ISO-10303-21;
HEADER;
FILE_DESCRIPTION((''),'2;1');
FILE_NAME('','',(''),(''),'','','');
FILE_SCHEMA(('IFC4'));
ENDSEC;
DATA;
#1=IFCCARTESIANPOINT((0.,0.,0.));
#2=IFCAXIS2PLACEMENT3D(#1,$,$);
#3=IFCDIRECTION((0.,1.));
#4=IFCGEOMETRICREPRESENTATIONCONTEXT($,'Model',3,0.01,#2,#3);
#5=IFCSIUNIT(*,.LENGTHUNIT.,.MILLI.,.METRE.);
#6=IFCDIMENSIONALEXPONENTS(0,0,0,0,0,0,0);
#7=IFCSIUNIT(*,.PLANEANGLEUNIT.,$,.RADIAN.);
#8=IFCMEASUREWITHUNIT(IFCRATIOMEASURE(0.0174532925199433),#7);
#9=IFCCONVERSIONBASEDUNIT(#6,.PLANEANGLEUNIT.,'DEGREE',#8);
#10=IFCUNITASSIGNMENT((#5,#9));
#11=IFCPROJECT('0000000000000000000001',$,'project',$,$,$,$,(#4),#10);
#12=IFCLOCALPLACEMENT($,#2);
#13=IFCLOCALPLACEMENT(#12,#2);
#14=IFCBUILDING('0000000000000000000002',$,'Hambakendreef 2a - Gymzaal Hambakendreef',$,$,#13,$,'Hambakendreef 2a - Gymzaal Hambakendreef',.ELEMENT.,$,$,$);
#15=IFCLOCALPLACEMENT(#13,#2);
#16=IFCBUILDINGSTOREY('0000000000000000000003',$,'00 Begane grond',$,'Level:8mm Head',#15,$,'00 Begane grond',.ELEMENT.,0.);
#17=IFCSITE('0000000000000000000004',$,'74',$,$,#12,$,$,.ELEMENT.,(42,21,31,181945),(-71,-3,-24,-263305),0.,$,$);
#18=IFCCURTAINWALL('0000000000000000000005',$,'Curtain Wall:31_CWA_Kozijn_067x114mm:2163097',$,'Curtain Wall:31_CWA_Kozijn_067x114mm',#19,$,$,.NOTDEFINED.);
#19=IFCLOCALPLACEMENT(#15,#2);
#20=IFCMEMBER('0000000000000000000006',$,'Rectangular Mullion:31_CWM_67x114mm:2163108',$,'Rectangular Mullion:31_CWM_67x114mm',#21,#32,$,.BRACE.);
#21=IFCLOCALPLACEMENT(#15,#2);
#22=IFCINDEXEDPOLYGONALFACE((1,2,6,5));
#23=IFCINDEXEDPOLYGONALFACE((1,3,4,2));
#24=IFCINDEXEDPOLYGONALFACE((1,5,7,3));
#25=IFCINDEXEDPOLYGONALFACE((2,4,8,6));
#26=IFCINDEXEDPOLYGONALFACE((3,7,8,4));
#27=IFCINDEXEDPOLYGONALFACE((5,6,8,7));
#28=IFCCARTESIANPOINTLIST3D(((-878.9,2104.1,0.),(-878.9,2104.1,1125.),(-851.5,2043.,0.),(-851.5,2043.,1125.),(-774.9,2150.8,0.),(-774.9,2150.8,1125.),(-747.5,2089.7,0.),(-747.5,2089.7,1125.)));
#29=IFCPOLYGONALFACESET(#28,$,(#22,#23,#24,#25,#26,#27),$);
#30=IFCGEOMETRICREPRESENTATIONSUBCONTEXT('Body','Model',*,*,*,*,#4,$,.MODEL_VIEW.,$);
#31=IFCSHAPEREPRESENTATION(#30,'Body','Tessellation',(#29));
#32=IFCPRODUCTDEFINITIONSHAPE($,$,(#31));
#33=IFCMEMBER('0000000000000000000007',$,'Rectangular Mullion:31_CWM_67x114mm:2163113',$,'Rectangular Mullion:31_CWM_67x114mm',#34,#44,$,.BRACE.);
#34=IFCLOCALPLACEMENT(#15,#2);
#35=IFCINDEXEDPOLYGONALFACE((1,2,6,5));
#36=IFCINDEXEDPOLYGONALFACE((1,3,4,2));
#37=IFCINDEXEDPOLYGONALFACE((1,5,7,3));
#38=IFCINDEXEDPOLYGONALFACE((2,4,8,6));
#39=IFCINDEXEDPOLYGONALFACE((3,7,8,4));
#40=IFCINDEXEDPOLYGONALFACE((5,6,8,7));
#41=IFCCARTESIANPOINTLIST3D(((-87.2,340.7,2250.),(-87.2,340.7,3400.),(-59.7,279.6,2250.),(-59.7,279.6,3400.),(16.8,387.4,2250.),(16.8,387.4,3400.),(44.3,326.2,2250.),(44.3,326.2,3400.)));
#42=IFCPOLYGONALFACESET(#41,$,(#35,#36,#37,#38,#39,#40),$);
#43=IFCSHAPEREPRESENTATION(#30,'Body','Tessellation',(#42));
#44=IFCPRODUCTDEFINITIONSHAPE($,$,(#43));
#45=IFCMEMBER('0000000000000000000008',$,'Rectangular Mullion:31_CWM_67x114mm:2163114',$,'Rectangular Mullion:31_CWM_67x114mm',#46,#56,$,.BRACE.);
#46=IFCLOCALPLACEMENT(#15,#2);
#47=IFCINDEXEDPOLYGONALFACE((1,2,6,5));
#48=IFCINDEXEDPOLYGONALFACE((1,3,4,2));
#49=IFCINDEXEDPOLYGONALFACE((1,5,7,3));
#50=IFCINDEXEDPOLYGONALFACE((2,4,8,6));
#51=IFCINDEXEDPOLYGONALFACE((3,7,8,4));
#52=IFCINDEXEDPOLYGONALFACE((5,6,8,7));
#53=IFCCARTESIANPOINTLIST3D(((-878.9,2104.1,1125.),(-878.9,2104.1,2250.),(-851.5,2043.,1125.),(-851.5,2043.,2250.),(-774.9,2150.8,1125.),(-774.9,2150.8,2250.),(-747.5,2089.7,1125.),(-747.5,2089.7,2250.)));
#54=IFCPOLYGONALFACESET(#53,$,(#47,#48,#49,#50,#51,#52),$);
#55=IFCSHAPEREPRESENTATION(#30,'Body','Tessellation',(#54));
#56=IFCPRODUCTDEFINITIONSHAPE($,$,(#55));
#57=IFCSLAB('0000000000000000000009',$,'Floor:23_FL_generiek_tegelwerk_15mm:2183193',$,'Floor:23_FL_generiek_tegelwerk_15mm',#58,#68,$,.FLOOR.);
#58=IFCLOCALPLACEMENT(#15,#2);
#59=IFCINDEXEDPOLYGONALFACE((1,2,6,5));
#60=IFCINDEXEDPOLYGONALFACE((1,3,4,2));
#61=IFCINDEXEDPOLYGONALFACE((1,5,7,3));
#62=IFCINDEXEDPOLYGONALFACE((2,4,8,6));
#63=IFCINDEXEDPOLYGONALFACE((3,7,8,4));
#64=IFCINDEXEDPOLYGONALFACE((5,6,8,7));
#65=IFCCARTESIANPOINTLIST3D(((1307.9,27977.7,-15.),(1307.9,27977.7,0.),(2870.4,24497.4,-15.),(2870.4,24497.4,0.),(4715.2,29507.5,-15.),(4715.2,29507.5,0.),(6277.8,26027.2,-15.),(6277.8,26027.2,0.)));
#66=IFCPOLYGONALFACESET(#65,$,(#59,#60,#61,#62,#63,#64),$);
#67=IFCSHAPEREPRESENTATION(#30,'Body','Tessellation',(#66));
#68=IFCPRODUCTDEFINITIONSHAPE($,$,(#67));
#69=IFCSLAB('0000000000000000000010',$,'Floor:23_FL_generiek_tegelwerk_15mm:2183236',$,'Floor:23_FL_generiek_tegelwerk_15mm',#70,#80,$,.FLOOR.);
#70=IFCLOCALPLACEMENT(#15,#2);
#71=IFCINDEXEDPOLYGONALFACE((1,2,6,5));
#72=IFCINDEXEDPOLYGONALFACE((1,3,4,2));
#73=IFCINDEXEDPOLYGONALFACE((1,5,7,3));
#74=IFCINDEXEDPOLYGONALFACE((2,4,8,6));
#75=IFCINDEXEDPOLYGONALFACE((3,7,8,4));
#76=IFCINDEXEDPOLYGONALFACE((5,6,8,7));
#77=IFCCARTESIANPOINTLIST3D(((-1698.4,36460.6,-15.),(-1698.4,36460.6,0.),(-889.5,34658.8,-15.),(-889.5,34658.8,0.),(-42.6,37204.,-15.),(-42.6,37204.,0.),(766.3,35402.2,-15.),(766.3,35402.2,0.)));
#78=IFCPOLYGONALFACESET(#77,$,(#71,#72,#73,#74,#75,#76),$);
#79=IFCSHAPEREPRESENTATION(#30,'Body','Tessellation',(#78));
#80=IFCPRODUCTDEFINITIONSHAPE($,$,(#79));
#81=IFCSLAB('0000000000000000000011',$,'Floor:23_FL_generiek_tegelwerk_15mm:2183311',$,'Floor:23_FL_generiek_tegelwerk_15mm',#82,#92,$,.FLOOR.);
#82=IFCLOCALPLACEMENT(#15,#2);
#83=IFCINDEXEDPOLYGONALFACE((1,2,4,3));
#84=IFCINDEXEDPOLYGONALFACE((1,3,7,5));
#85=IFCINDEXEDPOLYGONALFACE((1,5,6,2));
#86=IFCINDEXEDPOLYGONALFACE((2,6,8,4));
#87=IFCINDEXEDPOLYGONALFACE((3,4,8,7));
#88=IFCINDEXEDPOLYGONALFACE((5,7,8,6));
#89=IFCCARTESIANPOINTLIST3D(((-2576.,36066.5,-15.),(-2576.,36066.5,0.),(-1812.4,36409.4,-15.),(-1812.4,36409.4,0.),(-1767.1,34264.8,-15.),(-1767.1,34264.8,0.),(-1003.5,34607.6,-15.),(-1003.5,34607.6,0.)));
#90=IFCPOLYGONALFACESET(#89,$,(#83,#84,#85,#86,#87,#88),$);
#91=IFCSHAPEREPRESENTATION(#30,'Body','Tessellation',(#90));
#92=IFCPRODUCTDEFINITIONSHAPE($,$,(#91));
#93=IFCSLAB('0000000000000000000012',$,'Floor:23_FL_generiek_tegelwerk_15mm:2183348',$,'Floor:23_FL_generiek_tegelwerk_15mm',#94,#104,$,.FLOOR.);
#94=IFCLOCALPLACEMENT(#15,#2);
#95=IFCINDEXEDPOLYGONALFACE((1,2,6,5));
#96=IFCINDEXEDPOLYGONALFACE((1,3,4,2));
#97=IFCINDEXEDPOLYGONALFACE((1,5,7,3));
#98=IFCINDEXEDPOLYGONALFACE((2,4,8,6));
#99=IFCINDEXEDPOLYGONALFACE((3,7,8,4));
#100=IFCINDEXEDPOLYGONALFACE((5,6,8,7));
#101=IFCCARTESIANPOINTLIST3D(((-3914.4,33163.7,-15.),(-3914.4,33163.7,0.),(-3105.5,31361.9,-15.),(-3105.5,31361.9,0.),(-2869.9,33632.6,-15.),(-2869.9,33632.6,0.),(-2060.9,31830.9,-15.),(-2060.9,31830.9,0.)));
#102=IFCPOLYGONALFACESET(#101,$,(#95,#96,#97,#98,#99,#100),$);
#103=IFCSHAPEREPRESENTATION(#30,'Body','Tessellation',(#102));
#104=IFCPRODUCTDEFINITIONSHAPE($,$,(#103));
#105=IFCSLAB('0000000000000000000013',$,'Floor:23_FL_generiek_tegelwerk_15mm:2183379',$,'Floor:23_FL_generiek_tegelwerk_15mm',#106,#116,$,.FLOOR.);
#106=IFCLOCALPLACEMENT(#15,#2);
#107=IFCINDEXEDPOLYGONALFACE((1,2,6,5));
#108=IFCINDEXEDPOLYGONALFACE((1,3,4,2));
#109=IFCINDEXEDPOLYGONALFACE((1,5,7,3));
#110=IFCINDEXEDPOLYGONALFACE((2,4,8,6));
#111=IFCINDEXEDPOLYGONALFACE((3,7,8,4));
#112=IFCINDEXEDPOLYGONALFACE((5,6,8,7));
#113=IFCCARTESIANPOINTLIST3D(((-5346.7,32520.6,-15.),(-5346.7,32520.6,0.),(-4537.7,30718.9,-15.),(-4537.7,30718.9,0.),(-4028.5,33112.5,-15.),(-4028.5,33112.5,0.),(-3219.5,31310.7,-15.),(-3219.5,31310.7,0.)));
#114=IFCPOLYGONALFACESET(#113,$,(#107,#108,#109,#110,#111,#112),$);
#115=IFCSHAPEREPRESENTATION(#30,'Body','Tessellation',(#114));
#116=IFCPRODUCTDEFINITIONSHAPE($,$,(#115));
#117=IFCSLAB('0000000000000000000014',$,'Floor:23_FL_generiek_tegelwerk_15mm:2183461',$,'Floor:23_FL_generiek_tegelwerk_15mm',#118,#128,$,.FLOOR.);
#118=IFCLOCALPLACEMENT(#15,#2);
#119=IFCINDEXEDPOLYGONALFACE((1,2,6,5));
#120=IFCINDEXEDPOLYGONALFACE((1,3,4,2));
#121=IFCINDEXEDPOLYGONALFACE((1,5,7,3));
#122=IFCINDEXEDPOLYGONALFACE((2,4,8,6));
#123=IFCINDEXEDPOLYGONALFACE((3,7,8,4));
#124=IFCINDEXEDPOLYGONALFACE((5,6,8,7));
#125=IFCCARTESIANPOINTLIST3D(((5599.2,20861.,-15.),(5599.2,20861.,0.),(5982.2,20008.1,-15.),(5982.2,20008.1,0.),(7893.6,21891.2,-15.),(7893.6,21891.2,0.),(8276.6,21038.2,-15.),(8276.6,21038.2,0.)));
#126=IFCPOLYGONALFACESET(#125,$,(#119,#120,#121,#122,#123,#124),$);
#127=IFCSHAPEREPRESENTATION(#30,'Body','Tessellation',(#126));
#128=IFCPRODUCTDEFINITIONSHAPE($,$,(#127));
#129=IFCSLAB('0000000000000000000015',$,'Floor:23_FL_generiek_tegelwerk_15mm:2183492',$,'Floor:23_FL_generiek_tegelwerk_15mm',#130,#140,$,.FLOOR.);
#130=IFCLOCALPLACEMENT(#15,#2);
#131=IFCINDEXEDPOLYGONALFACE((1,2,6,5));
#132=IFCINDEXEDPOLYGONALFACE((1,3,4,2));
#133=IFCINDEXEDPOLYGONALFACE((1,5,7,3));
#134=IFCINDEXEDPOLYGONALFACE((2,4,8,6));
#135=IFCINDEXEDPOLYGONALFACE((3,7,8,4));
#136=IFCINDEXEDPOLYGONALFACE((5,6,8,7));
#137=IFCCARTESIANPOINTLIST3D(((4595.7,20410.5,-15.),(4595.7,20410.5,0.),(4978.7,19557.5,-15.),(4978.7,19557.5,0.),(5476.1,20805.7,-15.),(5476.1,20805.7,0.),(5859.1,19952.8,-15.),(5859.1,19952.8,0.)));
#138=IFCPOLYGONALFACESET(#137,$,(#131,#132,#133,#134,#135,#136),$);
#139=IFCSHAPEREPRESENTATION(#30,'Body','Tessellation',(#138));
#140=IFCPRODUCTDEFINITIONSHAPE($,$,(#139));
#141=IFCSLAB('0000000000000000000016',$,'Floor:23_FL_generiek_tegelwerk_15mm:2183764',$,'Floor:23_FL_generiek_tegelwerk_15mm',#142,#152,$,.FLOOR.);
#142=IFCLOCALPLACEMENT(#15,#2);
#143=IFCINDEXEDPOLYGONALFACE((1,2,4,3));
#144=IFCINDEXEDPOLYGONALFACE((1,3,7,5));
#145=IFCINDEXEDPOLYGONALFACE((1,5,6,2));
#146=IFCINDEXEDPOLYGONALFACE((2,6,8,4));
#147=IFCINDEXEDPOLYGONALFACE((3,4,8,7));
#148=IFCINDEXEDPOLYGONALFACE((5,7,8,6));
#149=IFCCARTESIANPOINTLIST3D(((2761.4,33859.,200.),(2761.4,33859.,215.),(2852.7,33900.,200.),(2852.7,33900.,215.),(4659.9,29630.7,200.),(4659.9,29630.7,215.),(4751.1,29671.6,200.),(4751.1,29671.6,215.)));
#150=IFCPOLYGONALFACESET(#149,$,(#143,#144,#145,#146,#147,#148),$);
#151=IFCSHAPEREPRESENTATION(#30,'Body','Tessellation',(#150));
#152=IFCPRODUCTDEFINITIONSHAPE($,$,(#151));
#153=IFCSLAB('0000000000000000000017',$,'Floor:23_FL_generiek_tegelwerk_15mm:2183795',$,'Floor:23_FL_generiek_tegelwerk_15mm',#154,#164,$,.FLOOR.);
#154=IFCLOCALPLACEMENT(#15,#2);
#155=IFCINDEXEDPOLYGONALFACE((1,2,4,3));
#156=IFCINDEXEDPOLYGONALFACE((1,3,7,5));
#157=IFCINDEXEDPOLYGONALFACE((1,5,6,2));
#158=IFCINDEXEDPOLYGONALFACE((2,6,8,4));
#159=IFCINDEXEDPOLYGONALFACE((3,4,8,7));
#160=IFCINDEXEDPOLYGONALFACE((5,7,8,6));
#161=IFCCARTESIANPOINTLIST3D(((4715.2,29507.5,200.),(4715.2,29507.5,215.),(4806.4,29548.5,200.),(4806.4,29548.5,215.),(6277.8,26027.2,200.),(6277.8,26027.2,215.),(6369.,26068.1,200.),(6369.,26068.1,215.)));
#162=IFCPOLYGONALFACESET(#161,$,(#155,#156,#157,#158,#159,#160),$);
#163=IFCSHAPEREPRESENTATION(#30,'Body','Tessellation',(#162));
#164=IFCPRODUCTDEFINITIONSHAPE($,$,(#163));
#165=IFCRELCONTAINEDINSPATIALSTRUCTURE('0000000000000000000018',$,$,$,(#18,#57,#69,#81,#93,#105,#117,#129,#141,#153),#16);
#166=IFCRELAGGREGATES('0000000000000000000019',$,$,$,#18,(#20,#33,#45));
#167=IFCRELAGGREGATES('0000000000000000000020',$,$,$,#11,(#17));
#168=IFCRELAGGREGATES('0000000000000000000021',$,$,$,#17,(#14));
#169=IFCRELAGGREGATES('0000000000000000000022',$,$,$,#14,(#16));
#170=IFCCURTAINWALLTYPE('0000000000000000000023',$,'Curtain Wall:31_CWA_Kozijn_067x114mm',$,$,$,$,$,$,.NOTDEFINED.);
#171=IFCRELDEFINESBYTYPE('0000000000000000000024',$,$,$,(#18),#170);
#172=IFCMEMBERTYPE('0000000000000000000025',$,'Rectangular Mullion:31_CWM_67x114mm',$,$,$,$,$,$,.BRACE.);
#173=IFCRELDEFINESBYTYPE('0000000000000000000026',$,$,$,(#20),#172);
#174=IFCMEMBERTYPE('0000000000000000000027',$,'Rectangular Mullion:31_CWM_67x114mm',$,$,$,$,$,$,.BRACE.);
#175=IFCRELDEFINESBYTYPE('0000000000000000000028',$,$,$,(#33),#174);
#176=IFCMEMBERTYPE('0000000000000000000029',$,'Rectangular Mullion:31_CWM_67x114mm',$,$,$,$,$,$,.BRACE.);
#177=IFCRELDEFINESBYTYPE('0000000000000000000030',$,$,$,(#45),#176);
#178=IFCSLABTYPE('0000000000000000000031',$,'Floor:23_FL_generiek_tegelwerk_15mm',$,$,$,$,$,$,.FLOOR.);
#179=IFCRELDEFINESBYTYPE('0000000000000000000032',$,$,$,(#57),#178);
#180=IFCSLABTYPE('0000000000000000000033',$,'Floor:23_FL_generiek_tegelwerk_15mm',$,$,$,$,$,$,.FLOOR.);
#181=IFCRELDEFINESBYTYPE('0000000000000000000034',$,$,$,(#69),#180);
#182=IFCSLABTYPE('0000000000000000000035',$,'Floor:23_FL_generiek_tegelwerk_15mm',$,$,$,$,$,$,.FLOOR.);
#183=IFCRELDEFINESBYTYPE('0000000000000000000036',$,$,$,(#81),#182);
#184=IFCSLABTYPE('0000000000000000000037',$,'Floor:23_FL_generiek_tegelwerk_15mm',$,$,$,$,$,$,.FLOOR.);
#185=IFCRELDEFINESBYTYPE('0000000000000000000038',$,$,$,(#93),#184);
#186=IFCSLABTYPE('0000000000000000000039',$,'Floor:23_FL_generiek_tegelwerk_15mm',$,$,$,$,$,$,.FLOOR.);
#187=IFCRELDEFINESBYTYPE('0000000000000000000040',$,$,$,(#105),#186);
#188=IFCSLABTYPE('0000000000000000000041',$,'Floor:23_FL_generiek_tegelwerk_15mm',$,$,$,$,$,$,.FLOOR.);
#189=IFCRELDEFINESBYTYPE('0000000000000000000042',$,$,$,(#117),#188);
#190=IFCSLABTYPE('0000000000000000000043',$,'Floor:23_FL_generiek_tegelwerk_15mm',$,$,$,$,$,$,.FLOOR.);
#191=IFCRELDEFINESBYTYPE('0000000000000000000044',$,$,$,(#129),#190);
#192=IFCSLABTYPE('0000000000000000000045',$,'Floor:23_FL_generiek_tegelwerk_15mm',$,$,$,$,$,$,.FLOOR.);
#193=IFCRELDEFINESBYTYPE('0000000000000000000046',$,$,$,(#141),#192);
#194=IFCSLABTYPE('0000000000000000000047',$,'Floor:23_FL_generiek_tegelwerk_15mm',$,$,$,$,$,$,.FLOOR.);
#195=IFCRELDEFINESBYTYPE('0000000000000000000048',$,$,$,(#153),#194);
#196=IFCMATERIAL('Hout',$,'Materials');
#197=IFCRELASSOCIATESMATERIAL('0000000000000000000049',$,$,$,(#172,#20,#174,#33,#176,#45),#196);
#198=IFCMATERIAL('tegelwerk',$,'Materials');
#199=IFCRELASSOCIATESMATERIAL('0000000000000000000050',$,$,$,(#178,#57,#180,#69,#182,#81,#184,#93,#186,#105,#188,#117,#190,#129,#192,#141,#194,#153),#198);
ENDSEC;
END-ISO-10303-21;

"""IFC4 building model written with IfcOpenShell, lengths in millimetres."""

from ifc_helpers import new_model, entity, si_unit, converted_unit, direction, frame, origin, place, context, subcontext, project, spatial, indexed_curve, outline, extrude, source, transform, mapped, material, type_object, type_shapes, element, aggregate, save


model = new_model("IFC4")

# Units and contexts
model_context = context("Model", 3, precision=0.01, world=origin(), true_north=direction((0.0, 1.0)))
body_context = subcontext(model_context, "Body", "Model", "MODEL_VIEW")
ifc_project = project(units=[si_unit("LENGTHUNIT", "METRE", prefix="MILLI"), converted_unit("PLANEANGLEUNIT", "DEGREE", entity("IfcRatioMeasure", 0.0174532925199433), si_unit("PLANEANGLEUNIT", "RADIAN"), dimensions=[0, 0, 0, 0, 0, 0, 0])], contexts=[model_context])

# Site, building, storey
site_placement = place(None, origin())
site = spatial("IfcSite", under=ifc_project, at=site_placement, Name="74", CompositionType="ELEMENT", RefLatitude=(42, 21, 31, 181945), RefLongitude=(-71, -3, -24, -263305), RefElevation=0.0)
building_placement = place(site_placement, origin())
building = spatial("IfcBuilding", under=site, at=building_placement, Name="Hambakendreef 2a - Gymzaal Hambakendreef", LongName="Hambakendreef 2a - Gymzaal Hambakendreef", CompositionType="ELEMENT")
storey_placement = place(building_placement, origin())
storey = spatial("IfcBuildingStorey", under=building, at=storey_placement, Name="00 Begane grond", ObjectType="Level:8mm Head", LongName="00 Begane grond", CompositionType="ELEMENT", Elevation=0.0)

# Curtain wall, members
curtain_wall_type = type_object("IfcCurtainWallType", Name="Curtain Wall:31_CWA_Kozijn_067x114mm", PredefinedType="NOTDEFINED")
curtain_wall_placement = place(storey_placement, origin())
curtain_wall = element("IfcCurtainWall", 1, at=curtain_wall_placement, inside=storey, type_object=curtain_wall_type, Name="Curtain Wall:31_CWA_Kozijn_067x114mm:2163097", ObjectType="Curtain Wall:31_CWA_Kozijn_067x114mm", PredefinedType="NOTDEFINED")
ifc_material_1 = material(Name="Hout", Category="Materials")
member_type_1 = type_object("IfcMemberType", Name="Rectangular Mullion:31_CWM_67x114mm", PredefinedType="BRACE", material=ifc_material_1)
shared_shape_1 = source(origin(), body_context, "Body", "SweptSolid", [
    extrude(outline(indexed_curve([(-57.0, -33.5), (57.0, -33.5), (57.0, 33.5), (-57.0, 33.5), (-57.0, -33.5)], self_intersect=False)), frame((-33.5, 0.0, -1125.0), z_axis=(0.0, 0.0, 1.0), x_axis=(0.0, -1.0, 0.0)), (0.0, 0.0, 1.0), 1125.0),
])
type_shapes(member_type_1, [shared_shape_1])
member_1_placement = place(storey_placement, frame((-826.9, 2127.4, 1125.0), z_axis=(0.0, 0.0, 1.0), x_axis=(-0.40959, 0.91227, 0.0)))
member_1 = element("IfcMember", 2, at=member_1_placement, type_object=member_type_1, material=ifc_material_1, Name="Rectangular Mullion:31_CWM_67x114mm:2163108", ObjectType="Rectangular Mullion:31_CWM_67x114mm", PredefinedType="BRACE", context=body_context, shape_type="MappedRepresentation", body=[
    mapped(shared_shape_1, transform((0.0, 0.0, 0.0), scale=1.0)),
])
member_type_2 = type_object("IfcMemberType", Name="Rectangular Mullion:31_CWM_67x114mm", PredefinedType="BRACE", material=ifc_material_1)
shared_shape_2 = source(origin(), body_context, "Body", "SweptSolid", [
    extrude(outline(indexed_curve([(-57.0, -33.5), (57.0, -33.5), (57.0, 33.5), (-57.0, 33.5), (-57.0, -33.5)], self_intersect=False)), frame((-33.5, 0.0, -1150.0), z_axis=(0.0, 0.0, 1.0), x_axis=(0.0, -1.0, 0.0)), (0.0, 0.0, 1.0), 1150.0),
])
type_shapes(member_type_2, [shared_shape_2])
member_2_placement = place(storey_placement, frame((-7.7, 302.9, 2250.0), z_axis=(0.0, 0.0, -1.0), x_axis=(0.40959, -0.91227, 0.0)))
member_2 = element("IfcMember", 3, at=member_2_placement, type_object=member_type_2, material=ifc_material_1, Name="Rectangular Mullion:31_CWM_67x114mm:2163113", ObjectType="Rectangular Mullion:31_CWM_67x114mm", PredefinedType="BRACE", context=body_context, shape_type="MappedRepresentation", body=[
    mapped(shared_shape_2, transform((0.0, 0.0, 0.0), scale=1.0)),
])
member_type_3 = type_object("IfcMemberType", Name="Rectangular Mullion:31_CWM_67x114mm", PredefinedType="BRACE", material=ifc_material_1)
shared_shape_3 = source(origin(), body_context, "Body", "SweptSolid", [
    extrude(outline(indexed_curve([(-57.0, -33.5), (57.0, -33.5), (57.0, 33.5), (-57.0, 33.5), (-57.0, -33.5)], self_intersect=False)), frame((-33.5, 0.0, -1125.0), z_axis=(0.0, 0.0, 1.0), x_axis=(0.0, -1.0, 0.0)), (0.0, 0.0, 1.0), 1125.0),
])
type_shapes(member_type_3, [shared_shape_3])
member_3_placement = place(storey_placement, frame((-826.9, 2127.4, 2250.0), z_axis=(0.0, 0.0, 1.0), x_axis=(-0.40959, 0.91227, 0.0)))
member_3 = element("IfcMember", 4, at=member_3_placement, type_object=member_type_3, material=ifc_material_1, Name="Rectangular Mullion:31_CWM_67x114mm:2163114", ObjectType="Rectangular Mullion:31_CWM_67x114mm", PredefinedType="BRACE", context=body_context, shape_type="MappedRepresentation", body=[
    mapped(shared_shape_3, transform((0.0, 0.0, 0.0), scale=1.0)),
])
aggregate(curtain_wall, [member_1, member_2, member_3])

# Slabs
ifc_material_2 = material(Name="tegelwerk", Category="Materials")
slab_type_1 = type_object("IfcSlabType", Name="Floor:23_FL_generiek_tegelwerk_15mm", PredefinedType="FLOOR", material=ifc_material_2)
slab_1_placement = place(storey_placement, origin())
element("IfcSlab", 5, at=slab_1_placement, inside=storey, type_object=slab_type_1, material=ifc_material_2, Name="Floor:23_FL_generiek_tegelwerk_15mm:2183193", ObjectType="Floor:23_FL_generiek_tegelwerk_15mm", PredefinedType="FLOOR", context=body_context, shape_type="SweptSolid", body=[
    extrude(outline(indexed_curve([(-1907.5, -1867.5), (1907.5, -1867.5), (1907.5, 1867.5), (-1907.5, 1867.5), (-1907.5, -1867.5)], self_intersect=False)), frame((3792.8, 27002.4, 0.0), z_axis=(0.0, 0.0, -1.0), x_axis=(0.40959, -0.91227, 0.0)), (0.0, 0.0, 1.0), 15.0),
])
slab_type_2 = type_object("IfcSlabType", Name="Floor:23_FL_generiek_tegelwerk_15mm", PredefinedType="FLOOR", material=ifc_material_2)
slab_2_placement = place(storey_placement, origin())
element("IfcSlab", 6, at=slab_2_placement, inside=storey, type_object=slab_type_2, material=ifc_material_2, Name="Floor:23_FL_generiek_tegelwerk_15mm:2183236", ObjectType="Floor:23_FL_generiek_tegelwerk_15mm", PredefinedType="FLOOR", context=body_context, shape_type="SweptSolid", body=[
    extrude(outline(indexed_curve([(-987.5, -907.5), (987.5, -907.5), (987.5, 907.5), (-987.5, 907.5), (-987.5, -907.5)], self_intersect=False)), frame((-466.0, 35931.4, 0.0), z_axis=(0.0, 0.0, -1.0), x_axis=(0.40959, -0.91227, 0.0)), (0.0, 0.0, 1.0), 15.0),
])
slab_type_3 = type_object("IfcSlabType", Name="Floor:23_FL_generiek_tegelwerk_15mm", PredefinedType="FLOOR", material=ifc_material_2)
slab_3_placement = place(storey_placement, origin())
element("IfcSlab", 7, at=slab_3_placement, inside=storey, type_object=slab_type_3, material=ifc_material_2, Name="Floor:23_FL_generiek_tegelwerk_15mm:2183311", ObjectType="Floor:23_FL_generiek_tegelwerk_15mm", PredefinedType="FLOOR", context=body_context, shape_type="SweptSolid", body=[
    extrude(outline(indexed_curve([(-987.5, -418.5), (987.5, -418.5), (987.5, 418.5), (-987.5, 418.5), (-987.5, -418.5)], self_intersect=False)), frame((-1789.7, 35337.1, 0.0), z_axis=(0.0, 0.0, -1.0), x_axis=(0.40959, -0.91227, 0.0)), (0.0, 0.0, 1.0), 15.0),
])
slab_type_4 = type_object("IfcSlabType", Name="Floor:23_FL_generiek_tegelwerk_15mm", PredefinedType="FLOOR", material=ifc_material_2)
slab_4_placement = place(storey_placement, origin())
element("IfcSlab", 8, at=slab_4_placement, inside=storey, type_object=slab_type_4, material=ifc_material_2, Name="Floor:23_FL_generiek_tegelwerk_15mm:2183348", ObjectType="Floor:23_FL_generiek_tegelwerk_15mm", PredefinedType="FLOOR", context=body_context, shape_type="SweptSolid", body=[
    extrude(outline(indexed_curve([(-987.5, -572.5), (987.5, -572.5), (987.5, 572.5), (-987.5, 572.5), (-987.5, -572.5)], self_intersect=False)), frame((-2987.7, 32497.3, 0.0), z_axis=(0.0, 0.0, -1.0), x_axis=(0.40959, -0.91227, 0.0)), (0.0, 0.0, 1.0), 15.0),
])
slab_type_5 = type_object("IfcSlabType", Name="Floor:23_FL_generiek_tegelwerk_15mm", PredefinedType="FLOOR", material=ifc_material_2)
slab_5_placement = place(storey_placement, origin())
element("IfcSlab", 9, at=slab_5_placement, inside=storey, type_object=slab_type_5, material=ifc_material_2, Name="Floor:23_FL_generiek_tegelwerk_15mm:2183379", ObjectType="Floor:23_FL_generiek_tegelwerk_15mm", PredefinedType="FLOOR", context=body_context, shape_type="SweptSolid", body=[
    extrude(outline(indexed_curve([(-987.5, -722.5), (987.5, -722.5), (987.5, 722.5), (-987.5, 722.5), (-987.5, -722.5)], self_intersect=False)), frame((-4283.1, 31915.7, 0.0), z_axis=(0.0, 0.0, -1.0), x_axis=(0.40959, -0.91227, 0.0)), (0.0, 0.0, 1.0), 15.0),
])
slab_type_6 = type_object("IfcSlabType", Name="Floor:23_FL_generiek_tegelwerk_15mm", PredefinedType="FLOOR", material=ifc_material_2)
slab_6_placement = place(storey_placement, origin())
element("IfcSlab", 10, at=slab_6_placement, inside=storey, type_object=slab_type_6, material=ifc_material_2, Name="Floor:23_FL_generiek_tegelwerk_15mm:2183461", ObjectType="Floor:23_FL_generiek_tegelwerk_15mm", PredefinedType="FLOOR", context=body_context, shape_type="SweptSolid", body=[
    extrude(outline(indexed_curve([(-467.5, -1257.5), (467.5, -1257.5), (467.5, 1257.5), (-467.5, 1257.5), (-467.5, -1257.5)], self_intersect=False)), frame((6937.9, 20949.6, 0.0), z_axis=(0.0, 0.0, -1.0), x_axis=(0.40959, -0.91227, 0.0)), (0.0, 0.0, 1.0), 15.0),
])
slab_type_7 = type_object("IfcSlabType", Name="Floor:23_FL_generiek_tegelwerk_15mm", PredefinedType="FLOOR", material=ifc_material_2)
slab_7_placement = place(storey_placement, origin())
element("IfcSlab", 11, at=slab_7_placement, inside=storey, type_object=slab_type_7, material=ifc_material_2, Name="Floor:23_FL_generiek_tegelwerk_15mm:2183492", ObjectType="Floor:23_FL_generiek_tegelwerk_15mm", PredefinedType="FLOOR", context=body_context, shape_type="SweptSolid", body=[
    extrude(outline(indexed_curve([(-467.5, -482.5), (467.5, -482.5), (467.5, 482.5), (-467.5, 482.5), (-467.5, -482.5)], self_intersect=False)), frame((5227.4, 20181.6, 0.0), z_axis=(0.0, 0.0, -1.0), x_axis=(0.40959, -0.91227, 0.0)), (0.0, 0.0, 1.0), 15.0),
])
slab_type_8 = type_object("IfcSlabType", Name="Floor:23_FL_generiek_tegelwerk_15mm", PredefinedType="FLOOR", material=ifc_material_2)
slab_8_placement = place(storey_placement, origin())
element("IfcSlab", 12, at=slab_8_placement, inside=storey, type_object=slab_type_8, material=ifc_material_2, Name="Floor:23_FL_generiek_tegelwerk_15mm:2183764", ObjectType="Floor:23_FL_generiek_tegelwerk_15mm", PredefinedType="FLOOR", context=body_context, shape_type="SweptSolid", body=[
    extrude(outline(indexed_curve([(-2317.5, -50.0), (2317.5, -50.0), (2317.5, 50.0), (-2317.5, 50.0), (-2317.5, -50.0)], self_intersect=False)), frame((3756.3, 31765.3, 215.0), z_axis=(0.0, 0.0, -1.0), x_axis=(0.40959, -0.91227, 0.0)), (0.0, 0.0, 1.0), 15.0),
])
slab_type_9 = type_object("IfcSlabType", Name="Floor:23_FL_generiek_tegelwerk_15mm", PredefinedType="FLOOR", material=ifc_material_2)
slab_9_placement = place(storey_placement, origin())
element("IfcSlab", 13, at=slab_9_placement, inside=storey, type_object=slab_type_9, material=ifc_material_2, Name="Floor:23_FL_generiek_tegelwerk_15mm:2183795", ObjectType="Floor:23_FL_generiek_tegelwerk_15mm", PredefinedType="FLOOR", context=body_context, shape_type="SweptSolid", body=[
    extrude(outline(indexed_curve([(-1907.5, -50.0), (1907.5, -50.0), (1907.5, 50.0), (-1907.5, 50.0), (-1907.5, -50.0)], self_intersect=False)), frame((5542.1, 27787.8, 215.0), z_axis=(0.0, 0.0, -1.0), x_axis=(0.40959, -0.91227, 0.0)), (0.0, 0.0, 1.0), 15.0),
])

save(model, "model.ifc")
